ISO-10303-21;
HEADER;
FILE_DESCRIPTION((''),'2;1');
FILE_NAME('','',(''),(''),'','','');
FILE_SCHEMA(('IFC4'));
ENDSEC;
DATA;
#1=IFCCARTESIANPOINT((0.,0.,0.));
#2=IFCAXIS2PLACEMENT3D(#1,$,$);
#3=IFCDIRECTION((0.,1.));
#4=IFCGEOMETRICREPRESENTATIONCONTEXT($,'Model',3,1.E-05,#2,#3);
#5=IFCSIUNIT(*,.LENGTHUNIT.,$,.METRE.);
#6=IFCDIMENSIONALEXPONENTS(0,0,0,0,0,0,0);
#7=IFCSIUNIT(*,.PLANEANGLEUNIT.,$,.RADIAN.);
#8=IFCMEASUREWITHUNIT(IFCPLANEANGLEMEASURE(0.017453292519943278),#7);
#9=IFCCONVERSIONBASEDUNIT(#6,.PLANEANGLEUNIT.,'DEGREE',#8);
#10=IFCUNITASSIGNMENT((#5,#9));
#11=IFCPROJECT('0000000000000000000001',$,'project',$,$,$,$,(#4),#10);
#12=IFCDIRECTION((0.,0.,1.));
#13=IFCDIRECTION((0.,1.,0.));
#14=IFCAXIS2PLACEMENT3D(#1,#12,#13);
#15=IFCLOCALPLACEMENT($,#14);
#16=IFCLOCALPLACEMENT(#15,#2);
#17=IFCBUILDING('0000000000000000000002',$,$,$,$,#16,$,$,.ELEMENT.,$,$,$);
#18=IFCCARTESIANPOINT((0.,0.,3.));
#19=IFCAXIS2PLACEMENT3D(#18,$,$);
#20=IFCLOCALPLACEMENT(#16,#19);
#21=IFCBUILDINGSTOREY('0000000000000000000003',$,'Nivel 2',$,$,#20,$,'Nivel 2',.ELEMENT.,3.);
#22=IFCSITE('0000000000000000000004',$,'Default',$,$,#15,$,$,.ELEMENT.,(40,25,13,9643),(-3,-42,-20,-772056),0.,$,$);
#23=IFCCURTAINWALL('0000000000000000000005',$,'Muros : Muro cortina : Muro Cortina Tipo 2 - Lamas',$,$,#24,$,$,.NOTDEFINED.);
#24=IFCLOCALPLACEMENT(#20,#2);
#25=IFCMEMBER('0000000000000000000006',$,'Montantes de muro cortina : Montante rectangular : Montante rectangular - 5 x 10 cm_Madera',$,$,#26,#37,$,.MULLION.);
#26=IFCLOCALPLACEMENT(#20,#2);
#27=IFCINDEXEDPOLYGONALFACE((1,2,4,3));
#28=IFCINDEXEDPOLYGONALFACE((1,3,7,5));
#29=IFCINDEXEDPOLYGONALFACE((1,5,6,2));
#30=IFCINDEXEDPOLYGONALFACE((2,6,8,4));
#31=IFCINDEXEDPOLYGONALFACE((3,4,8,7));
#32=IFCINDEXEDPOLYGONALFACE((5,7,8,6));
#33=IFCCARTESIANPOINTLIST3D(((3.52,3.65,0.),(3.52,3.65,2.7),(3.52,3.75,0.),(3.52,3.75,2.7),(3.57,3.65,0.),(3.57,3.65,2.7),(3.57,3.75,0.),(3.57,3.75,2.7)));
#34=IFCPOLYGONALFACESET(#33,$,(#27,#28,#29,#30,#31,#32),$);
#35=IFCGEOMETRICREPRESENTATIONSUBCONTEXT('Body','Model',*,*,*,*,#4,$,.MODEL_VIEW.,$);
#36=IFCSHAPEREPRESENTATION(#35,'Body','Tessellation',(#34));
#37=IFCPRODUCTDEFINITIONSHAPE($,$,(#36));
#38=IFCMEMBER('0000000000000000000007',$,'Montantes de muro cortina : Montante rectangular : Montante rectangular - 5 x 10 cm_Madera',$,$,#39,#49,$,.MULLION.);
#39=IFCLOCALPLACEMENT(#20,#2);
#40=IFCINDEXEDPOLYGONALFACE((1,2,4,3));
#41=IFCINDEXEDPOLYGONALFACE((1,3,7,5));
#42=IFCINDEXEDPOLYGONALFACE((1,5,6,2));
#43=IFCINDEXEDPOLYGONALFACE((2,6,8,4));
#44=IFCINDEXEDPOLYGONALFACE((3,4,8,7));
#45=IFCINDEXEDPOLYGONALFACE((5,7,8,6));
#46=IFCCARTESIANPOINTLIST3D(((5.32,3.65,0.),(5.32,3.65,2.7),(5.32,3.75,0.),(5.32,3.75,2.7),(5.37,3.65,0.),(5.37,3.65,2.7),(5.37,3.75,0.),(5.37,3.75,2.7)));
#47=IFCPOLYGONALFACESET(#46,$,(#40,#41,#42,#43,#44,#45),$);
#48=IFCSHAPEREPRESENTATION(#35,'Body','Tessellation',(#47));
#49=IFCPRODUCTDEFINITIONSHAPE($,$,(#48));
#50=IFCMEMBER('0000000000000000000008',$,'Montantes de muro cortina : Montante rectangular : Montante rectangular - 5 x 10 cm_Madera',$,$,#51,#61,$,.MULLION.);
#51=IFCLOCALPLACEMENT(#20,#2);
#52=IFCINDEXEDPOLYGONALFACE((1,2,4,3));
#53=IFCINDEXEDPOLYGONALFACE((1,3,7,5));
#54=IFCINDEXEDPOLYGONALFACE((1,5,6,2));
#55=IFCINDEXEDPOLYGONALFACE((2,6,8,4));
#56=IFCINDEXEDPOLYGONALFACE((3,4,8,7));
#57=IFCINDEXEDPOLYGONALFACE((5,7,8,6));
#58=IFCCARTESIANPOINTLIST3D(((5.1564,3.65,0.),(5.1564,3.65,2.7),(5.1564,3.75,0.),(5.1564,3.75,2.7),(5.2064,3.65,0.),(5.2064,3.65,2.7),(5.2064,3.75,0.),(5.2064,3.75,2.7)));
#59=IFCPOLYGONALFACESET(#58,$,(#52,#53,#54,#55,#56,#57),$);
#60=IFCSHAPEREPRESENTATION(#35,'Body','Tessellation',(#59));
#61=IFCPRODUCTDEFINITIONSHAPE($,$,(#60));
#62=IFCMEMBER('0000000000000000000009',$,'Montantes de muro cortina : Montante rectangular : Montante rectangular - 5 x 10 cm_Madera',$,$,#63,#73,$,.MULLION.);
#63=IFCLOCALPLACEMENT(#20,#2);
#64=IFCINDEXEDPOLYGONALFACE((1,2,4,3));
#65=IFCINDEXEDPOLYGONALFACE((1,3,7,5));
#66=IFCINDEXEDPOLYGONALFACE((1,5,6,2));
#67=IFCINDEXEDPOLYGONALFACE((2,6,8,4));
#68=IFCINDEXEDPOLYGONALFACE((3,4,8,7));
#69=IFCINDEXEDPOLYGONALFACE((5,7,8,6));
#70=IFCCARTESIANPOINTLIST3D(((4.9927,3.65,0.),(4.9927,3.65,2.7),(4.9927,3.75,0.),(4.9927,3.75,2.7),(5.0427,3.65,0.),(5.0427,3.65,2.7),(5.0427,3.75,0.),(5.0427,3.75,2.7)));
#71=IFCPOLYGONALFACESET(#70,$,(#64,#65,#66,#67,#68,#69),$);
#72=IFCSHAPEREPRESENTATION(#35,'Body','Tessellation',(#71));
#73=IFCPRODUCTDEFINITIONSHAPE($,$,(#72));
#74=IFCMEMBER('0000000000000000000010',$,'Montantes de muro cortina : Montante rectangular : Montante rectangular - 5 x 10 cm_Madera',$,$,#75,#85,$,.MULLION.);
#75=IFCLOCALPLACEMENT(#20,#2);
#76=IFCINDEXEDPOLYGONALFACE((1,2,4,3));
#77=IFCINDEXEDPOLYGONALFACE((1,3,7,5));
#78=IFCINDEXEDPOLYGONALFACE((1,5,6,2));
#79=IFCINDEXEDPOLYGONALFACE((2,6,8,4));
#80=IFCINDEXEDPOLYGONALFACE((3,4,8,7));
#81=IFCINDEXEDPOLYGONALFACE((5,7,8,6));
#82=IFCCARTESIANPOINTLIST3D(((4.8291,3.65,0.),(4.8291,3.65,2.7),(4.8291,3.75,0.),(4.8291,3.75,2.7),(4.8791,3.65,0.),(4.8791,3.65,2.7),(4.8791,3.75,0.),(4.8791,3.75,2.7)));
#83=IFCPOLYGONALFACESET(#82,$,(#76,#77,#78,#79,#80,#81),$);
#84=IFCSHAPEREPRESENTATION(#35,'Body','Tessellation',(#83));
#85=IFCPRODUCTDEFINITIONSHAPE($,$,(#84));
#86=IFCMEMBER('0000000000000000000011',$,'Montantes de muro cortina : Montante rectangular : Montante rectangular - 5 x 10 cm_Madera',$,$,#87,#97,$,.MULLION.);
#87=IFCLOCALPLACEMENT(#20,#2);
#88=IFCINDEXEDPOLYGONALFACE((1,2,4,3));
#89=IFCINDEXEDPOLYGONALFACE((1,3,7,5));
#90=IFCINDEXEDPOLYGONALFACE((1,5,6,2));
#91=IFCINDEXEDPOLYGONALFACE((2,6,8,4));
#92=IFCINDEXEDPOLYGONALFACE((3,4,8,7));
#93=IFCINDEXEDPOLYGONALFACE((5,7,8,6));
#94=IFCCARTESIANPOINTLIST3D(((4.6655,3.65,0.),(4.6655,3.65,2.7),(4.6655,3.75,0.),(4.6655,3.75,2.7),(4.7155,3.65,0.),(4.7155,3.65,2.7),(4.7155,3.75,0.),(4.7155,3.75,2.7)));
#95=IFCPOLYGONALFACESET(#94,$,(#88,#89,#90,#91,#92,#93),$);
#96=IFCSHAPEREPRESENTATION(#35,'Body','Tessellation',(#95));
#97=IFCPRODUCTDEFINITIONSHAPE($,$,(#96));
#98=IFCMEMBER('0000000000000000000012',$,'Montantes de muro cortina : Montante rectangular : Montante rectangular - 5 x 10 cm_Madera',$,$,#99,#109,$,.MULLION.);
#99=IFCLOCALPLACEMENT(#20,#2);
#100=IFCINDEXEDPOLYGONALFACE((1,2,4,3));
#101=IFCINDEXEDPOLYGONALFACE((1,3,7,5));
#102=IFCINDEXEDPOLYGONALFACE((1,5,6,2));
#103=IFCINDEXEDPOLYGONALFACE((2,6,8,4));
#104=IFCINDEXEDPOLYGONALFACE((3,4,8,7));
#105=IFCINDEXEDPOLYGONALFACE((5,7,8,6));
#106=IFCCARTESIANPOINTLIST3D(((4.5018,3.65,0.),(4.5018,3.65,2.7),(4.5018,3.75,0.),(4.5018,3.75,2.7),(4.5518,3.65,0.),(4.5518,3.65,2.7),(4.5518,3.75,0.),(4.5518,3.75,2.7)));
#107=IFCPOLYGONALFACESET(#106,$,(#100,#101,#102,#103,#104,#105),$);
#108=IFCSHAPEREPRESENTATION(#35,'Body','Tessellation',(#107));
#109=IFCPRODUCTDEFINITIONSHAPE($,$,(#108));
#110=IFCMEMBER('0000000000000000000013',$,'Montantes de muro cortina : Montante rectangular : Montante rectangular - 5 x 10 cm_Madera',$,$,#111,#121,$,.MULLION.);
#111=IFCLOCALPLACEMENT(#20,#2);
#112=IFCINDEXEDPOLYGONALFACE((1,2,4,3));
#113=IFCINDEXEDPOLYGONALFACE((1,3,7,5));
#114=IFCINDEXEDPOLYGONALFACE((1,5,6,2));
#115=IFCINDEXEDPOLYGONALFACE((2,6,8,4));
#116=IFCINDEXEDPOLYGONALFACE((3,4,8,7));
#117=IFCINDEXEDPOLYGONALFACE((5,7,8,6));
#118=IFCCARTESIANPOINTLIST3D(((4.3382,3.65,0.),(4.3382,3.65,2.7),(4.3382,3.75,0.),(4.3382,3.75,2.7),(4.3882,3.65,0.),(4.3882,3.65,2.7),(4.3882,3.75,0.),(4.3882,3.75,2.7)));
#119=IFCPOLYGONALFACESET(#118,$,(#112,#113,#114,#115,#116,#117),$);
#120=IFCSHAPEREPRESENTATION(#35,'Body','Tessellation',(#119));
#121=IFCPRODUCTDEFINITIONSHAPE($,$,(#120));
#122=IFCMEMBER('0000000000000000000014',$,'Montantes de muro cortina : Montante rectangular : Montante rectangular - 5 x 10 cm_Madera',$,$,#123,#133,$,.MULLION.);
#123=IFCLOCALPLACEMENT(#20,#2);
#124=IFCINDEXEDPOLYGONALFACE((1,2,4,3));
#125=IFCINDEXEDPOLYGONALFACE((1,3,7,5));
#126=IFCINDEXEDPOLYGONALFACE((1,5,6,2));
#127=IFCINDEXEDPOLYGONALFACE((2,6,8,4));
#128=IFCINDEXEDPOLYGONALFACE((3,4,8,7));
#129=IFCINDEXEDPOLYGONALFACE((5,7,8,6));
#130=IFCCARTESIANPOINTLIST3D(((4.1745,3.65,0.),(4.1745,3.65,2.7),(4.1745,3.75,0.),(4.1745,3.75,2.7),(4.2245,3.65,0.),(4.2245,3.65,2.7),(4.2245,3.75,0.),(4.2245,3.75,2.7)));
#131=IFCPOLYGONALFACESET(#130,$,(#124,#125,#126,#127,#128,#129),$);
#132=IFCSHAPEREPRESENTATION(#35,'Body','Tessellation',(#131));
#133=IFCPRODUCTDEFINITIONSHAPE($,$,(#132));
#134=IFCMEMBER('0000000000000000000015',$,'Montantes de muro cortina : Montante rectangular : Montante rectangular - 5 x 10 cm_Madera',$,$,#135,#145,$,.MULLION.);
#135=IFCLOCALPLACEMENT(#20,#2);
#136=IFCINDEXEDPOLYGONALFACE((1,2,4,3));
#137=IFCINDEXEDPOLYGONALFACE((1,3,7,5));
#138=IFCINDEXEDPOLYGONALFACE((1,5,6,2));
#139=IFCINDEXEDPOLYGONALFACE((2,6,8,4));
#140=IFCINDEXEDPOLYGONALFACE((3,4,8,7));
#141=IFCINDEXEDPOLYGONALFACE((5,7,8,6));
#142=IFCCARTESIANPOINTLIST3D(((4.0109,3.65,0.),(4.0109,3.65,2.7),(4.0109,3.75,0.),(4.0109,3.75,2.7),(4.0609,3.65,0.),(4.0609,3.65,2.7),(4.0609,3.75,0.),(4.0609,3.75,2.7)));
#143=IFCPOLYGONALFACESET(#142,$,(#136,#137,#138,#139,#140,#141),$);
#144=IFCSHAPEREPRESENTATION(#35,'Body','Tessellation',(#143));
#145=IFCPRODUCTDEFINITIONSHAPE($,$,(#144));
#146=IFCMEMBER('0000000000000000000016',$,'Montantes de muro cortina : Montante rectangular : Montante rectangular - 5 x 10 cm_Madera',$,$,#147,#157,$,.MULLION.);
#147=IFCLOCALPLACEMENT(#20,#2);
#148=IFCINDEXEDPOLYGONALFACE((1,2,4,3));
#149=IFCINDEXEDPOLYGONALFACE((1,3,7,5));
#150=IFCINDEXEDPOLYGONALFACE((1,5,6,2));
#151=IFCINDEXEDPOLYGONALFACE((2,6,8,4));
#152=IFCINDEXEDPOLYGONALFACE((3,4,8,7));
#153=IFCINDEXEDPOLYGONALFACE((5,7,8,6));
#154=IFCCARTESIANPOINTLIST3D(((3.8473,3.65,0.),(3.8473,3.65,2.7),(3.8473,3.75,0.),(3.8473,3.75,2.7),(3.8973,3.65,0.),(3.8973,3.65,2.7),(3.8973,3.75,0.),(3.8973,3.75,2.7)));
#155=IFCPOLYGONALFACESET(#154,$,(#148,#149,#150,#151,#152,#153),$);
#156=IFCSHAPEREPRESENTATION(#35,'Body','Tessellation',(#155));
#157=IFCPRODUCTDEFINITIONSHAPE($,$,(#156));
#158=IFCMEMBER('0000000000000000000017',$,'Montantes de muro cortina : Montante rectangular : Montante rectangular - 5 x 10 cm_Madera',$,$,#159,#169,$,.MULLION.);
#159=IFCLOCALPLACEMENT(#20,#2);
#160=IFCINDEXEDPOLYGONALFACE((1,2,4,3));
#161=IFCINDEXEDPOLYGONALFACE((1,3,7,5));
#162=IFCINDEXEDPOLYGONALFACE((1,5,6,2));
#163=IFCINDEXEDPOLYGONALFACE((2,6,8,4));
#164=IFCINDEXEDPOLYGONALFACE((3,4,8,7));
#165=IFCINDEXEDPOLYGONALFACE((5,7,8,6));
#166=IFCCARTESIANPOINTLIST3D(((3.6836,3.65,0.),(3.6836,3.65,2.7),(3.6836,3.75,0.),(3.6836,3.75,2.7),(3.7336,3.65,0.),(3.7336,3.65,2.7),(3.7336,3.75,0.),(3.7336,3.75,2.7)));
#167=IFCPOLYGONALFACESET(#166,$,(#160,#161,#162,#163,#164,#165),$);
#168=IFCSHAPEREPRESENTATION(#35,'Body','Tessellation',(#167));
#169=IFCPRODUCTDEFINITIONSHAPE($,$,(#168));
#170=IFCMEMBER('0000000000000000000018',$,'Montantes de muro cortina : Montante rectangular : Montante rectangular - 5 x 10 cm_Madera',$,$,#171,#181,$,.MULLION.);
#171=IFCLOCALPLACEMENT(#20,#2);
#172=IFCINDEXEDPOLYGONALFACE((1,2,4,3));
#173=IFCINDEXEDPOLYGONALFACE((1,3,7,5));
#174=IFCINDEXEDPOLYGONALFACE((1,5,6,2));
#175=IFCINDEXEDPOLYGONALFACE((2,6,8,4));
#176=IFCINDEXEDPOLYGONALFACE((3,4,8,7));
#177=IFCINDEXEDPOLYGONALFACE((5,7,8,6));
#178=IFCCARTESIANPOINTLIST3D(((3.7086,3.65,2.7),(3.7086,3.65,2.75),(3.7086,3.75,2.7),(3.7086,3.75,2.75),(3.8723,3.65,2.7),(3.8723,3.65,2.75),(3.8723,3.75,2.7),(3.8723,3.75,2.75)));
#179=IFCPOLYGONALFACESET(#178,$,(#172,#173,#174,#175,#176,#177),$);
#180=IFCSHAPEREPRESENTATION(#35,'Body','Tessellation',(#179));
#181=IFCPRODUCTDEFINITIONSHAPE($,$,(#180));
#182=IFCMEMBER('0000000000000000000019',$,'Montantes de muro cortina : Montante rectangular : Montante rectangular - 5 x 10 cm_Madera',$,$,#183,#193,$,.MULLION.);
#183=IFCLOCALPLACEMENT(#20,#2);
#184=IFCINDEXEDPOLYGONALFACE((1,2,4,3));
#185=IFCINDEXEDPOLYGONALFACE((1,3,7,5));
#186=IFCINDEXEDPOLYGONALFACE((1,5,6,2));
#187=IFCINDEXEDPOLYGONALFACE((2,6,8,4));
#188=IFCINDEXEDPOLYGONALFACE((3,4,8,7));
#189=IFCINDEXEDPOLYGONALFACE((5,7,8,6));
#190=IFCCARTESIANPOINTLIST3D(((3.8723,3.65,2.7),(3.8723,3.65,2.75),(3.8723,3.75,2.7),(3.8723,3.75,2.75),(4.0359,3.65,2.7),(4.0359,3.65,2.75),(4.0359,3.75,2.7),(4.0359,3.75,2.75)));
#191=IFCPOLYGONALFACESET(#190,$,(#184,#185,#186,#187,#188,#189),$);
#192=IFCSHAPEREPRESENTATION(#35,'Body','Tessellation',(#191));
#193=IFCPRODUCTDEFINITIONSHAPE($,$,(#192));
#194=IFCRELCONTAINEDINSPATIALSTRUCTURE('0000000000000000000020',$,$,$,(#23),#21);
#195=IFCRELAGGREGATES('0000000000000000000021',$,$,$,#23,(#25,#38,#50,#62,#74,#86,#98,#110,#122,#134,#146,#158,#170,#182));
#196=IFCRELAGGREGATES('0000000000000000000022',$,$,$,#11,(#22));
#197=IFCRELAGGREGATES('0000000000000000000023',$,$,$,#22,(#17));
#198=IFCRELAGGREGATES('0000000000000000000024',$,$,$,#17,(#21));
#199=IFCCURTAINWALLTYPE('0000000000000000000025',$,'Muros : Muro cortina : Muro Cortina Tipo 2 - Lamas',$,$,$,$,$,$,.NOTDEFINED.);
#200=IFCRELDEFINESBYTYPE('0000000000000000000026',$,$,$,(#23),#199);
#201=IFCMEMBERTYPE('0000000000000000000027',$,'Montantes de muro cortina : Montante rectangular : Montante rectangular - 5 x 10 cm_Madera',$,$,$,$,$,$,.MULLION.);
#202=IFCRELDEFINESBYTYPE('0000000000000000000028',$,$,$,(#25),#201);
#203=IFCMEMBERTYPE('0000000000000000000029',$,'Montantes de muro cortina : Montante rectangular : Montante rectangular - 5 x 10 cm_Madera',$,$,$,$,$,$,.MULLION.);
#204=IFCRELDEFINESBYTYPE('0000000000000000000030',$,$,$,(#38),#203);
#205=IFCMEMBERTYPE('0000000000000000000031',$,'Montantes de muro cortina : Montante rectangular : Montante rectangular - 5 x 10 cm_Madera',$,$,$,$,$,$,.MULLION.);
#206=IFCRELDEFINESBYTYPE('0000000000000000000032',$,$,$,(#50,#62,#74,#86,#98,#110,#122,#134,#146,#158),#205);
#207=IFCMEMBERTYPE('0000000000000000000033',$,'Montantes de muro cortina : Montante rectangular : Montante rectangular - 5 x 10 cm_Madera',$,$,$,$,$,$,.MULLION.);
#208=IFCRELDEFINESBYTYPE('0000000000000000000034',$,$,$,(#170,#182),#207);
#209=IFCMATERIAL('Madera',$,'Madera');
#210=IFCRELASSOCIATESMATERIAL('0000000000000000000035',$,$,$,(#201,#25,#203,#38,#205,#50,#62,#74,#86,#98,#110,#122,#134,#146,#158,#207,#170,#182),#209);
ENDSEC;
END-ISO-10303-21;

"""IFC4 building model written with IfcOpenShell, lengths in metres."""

from ifc_helpers import new_model, entity, si_unit, converted_unit, direction, frame, origin, place, context, subcontext, project, spatial, indexed_curve, outline, extrude, source, transform, mapped, material, type_object, type_shapes, element, aggregate, save


model = new_model("IFC4")

# Units and contexts
model_context = context("Model", 3, precision=1e-05, world=origin(), true_north=direction((0.0, 1.0)))
body_context = subcontext(model_context, "Body", "Model", "MODEL_VIEW")
ifc_project = project(units=[si_unit("LENGTHUNIT", "METRE"), converted_unit("PLANEANGLEUNIT", "DEGREE", entity("IfcPlaneAngleMeasure", 0.017453292519943278), si_unit("PLANEANGLEUNIT", "RADIAN"), dimensions=[0, 0, 0, 0, 0, 0, 0])], contexts=[model_context])

# Site, building, storey
site_placement = place(None, frame((0.0, 0.0, 0.0), z_axis=(0.0, 0.0, 1.0), x_axis=(0.0, 1.0, 0.0)))
site = spatial("IfcSite", under=ifc_project, at=site_placement, Name="Default", CompositionType="ELEMENT", RefLatitude=(40, 25, 13, 9643), RefLongitude=(-3, -42, -20, -772056), RefElevation=0.0)
building_placement = place(site_placement, origin())
building = spatial("IfcBuilding", under=site, at=building_placement, CompositionType="ELEMENT")
storey_placement = place(building_placement, frame((0.0, 0.0, 3.0)))
storey = spatial("IfcBuildingStorey", under=building, at=storey_placement, Name="Nivel 2", LongName="Nivel 2", CompositionType="ELEMENT", Elevation=3.0)

# Curtain wall, members
curtain_wall_type = type_object("IfcCurtainWallType", Name="Muros : Muro cortina : Muro Cortina Tipo 2 - Lamas", PredefinedType="NOTDEFINED")
curtain_wall_placement = place(storey_placement, frame((0.0, 0.0, -3.0)))
curtain_wall = element("IfcCurtainWall", 1, at=curtain_wall_placement, inside=storey, type_object=curtain_wall_type, Name="Muros : Muro cortina : Muro Cortina Tipo 2 - Lamas", PredefinedType="NOTDEFINED")
ifc_material_1 = material(Name="Madera", Category="Madera")
member_type_1 = type_object("IfcMemberType", Name="Montantes de muro cortina : Montante rectangular : Montante rectangular - 5 x 10 cm_Madera", PredefinedType="MULLION", material=ifc_material_1)
shared_shape_1 = source(origin(), body_context, "Body", "SweptSolid", [
    extrude(outline(indexed_curve([(-0.025, -0.05), (0.025, -0.05), (0.025, 0.05), (-0.025, 0.05), (-0.025, -0.05)], self_intersect=False)), frame((-0.025, 0.0, -2.7), z_axis=(0.0, 0.0, 1.0), x_axis=(-1.0, 0.0, 0.0)), (0.0, 0.0, 1.0), 2.7),
])
type_shapes(member_type_1, [shared_shape_1])
member_1_placement = place(curtain_wall_placement, frame((3.52, 3.7, 3.0), z_axis=(0.0, 0.0, -1.0), x_axis=(-1.0, 0.0, 0.0)))
member_1 = element("IfcMember", 2, at=member_1_placement, type_object=member_type_1, material=ifc_material_1, Name="Montantes de muro cortina : Montante rectangular : Montante rectangular - 5 x 10 cm_Madera", PredefinedType="MULLION", context=body_context, shape_type="MappedRepresentation", body=[
    mapped(shared_shape_1, transform((0.0, 0.0, 0.0), scale=1.0)),
])
member_type_2 = type_object("IfcMemberType", Name="Montantes de muro cortina : Montante rectangular : Montante rectangular - 5 x 10 cm_Madera", PredefinedType="MULLION", material=ifc_material_1)
shared_shape_2 = source(origin(), body_context, "Body", "SweptSolid", [
    extrude(outline(indexed_curve([(-0.05, -0.025), (0.05, -0.025), (0.05, 0.025), (-0.05, 0.025), (-0.05, -0.025)], self_intersect=False)), frame((-0.025, 0.0, -2.7), z_axis=(0.0, 0.0, 1.0), x_axis=(0.0, -1.0, 0.0)), (0.0, 0.0, 1.0), 2.7),
])
type_shapes(member_type_2, [shared_shape_2])
member_2_placement = place(curtain_wall_placement, frame((5.37, 3.7, 5.7)))
member_2 = element("IfcMember", 3, at=member_2_placement, type_object=member_type_2, material=ifc_material_1, Name="Montantes de muro cortina : Montante rectangular : Montante rectangular - 5 x 10 cm_Madera", PredefinedType="MULLION", context=body_context, shape_type="MappedRepresentation", body=[
    mapped(shared_shape_2, transform((0.0, 0.0, 0.0), scale=1.0)),
])
member_type_3 = type_object("IfcMemberType", Name="Montantes de muro cortina : Montante rectangular : Montante rectangular - 5 x 10 cm_Madera", PredefinedType="MULLION", material=ifc_material_1)
shared_shape_3 = source(origin(), body_context, "Body", "SweptSolid", [
    extrude(outline(indexed_curve([(-0.025, -0.05), (0.025, -0.05), (0.025, 0.05), (-0.025, 0.05), (-0.025, -0.05)], self_intersect=False)), frame((0.0, 0.0, -2.7), z_axis=(0.0, 0.0, 1.0), x_axis=(-1.0, 0.0, 0.0)), (0.0, 0.0, 1.0), 2.7),
])
type_shapes(member_type_3, [shared_shape_3])
member_3_placement = place(curtain_wall_placement, frame((5.1814, 3.7, 3.0), z_axis=(0.0, 0.0, -1.0), x_axis=(-1.0, 0.0, 0.0)))
member_3 = element("IfcMember", 4, at=member_3_placement, type_object=member_type_3, material=ifc_material_1, Name="Montantes de muro cortina : Montante rectangular : Montante rectangular - 5 x 10 cm_Madera", PredefinedType="MULLION", context=body_context, shape_type="MappedRepresentation", body=[
    mapped(shared_shape_3, transform((0.0, 0.0, 0.0), scale=1.0)),
])
member_4_placement = place(curtain_wall_placement, frame((5.0177, 3.7, 3.0), z_axis=(0.0, 0.0, -1.0), x_axis=(-1.0, 0.0, 0.0)))
member_4 = element("IfcMember", 5, at=member_4_placement, type_object=member_type_3, material=ifc_material_1, Name="Montantes de muro cortina : Montante rectangular : Montante rectangular - 5 x 10 cm_Madera", PredefinedType="MULLION", context=body_context, shape_type="MappedRepresentation", body=[
    mapped(shared_shape_3, transform((0.0, 0.0, 0.0), scale=1.0)),
])
member_5_placement = place(curtain_wall_placement, frame((4.8541, 3.7, 3.0), z_axis=(0.0, 0.0, -1.0), x_axis=(-1.0, 0.0, 0.0)))
member_5 = element("IfcMember", 6, at=member_5_placement, type_object=member_type_3, material=ifc_material_1, Name="Montantes de muro cortina : Montante rectangular : Montante rectangular - 5 x 10 cm_Madera", PredefinedType="MULLION", context=body_context, shape_type="MappedRepresentation", body=[
    mapped(shared_shape_3, transform((0.0, 0.0, 0.0), scale=1.0)),
])
member_6_placement = place(curtain_wall_placement, frame((4.6905, 3.7, 3.0), z_axis=(0.0, 0.0, -1.0), x_axis=(-1.0, 0.0, 0.0)))
member_6 = element("IfcMember", 7, at=member_6_placement, type_object=member_type_3, material=ifc_material_1, Name="Montantes de muro cortina : Montante rectangular : Montante rectangular - 5 x 10 cm_Madera", PredefinedType="MULLION", context=body_context, shape_type="MappedRepresentation", body=[
    mapped(shared_shape_3, transform((0.0, 0.0, 0.0), scale=1.0)),
])
member_7_placement = place(curtain_wall_placement, frame((4.5268, 3.7, 3.0), z_axis=(0.0, 0.0, -1.0), x_axis=(-1.0, 0.0, 0.0)))
member_7 = element("IfcMember", 8, at=member_7_placement, type_object=member_type_3, material=ifc_material_1, Name="Montantes de muro cortina : Montante rectangular : Montante rectangular - 5 x 10 cm_Madera", PredefinedType="MULLION", context=body_context, shape_type="MappedRepresentation", body=[
    mapped(shared_shape_3, transform((0.0, 0.0, 0.0), scale=1.0)),
])
member_8_placement = place(curtain_wall_placement, frame((4.3632, 3.7, 3.0), z_axis=(0.0, 0.0, -1.0), x_axis=(-1.0, 0.0, 0.0)))
member_8 = element("IfcMember", 9, at=member_8_placement, type_object=member_type_3, material=ifc_material_1, Name="Montantes de muro cortina : Montante rectangular : Montante rectangular - 5 x 10 cm_Madera", PredefinedType="MULLION", context=body_context, shape_type="MappedRepresentation", body=[
    mapped(shared_shape_3, transform((0.0, 0.0, 0.0), scale=1.0)),
])
member_9_placement = place(curtain_wall_placement, frame((4.1995, 3.7, 3.0), z_axis=(0.0, 0.0, -1.0), x_axis=(-1.0, 0.0, 0.0)))
member_9 = element("IfcMember", 10, at=member_9_placement, type_object=member_type_3, material=ifc_material_1, Name="Montantes de muro cortina : Montante rectangular : Montante rectangular - 5 x 10 cm_Madera", PredefinedType="MULLION", context=body_context, shape_type="MappedRepresentation", body=[
    mapped(shared_shape_3, transform((0.0, 0.0, 0.0), scale=1.0)),
])
member_10_placement = place(curtain_wall_placement, frame((4.0359, 3.7, 3.0), z_axis=(0.0, 0.0, -1.0), x_axis=(-1.0, 0.0, 0.0)))
member_10 = element("IfcMember", 11, at=member_10_placement, type_object=member_type_3, material=ifc_material_1, Name="Montantes de muro cortina : Montante rectangular : Montante rectangular - 5 x 10 cm_Madera", PredefinedType="MULLION", context=body_context, shape_type="MappedRepresentation", body=[
    mapped(shared_shape_3, transform((0.0, 0.0, 0.0), scale=1.0)),
])
member_11_placement = place(curtain_wall_placement, frame((3.8723, 3.7, 3.0), z_axis=(0.0, 0.0, -1.0), x_axis=(-1.0, 0.0, 0.0)))
member_11 = element("IfcMember", 12, at=member_11_placement, type_object=member_type_3, material=ifc_material_1, Name="Montantes de muro cortina : Montante rectangular : Montante rectangular - 5 x 10 cm_Madera", PredefinedType="MULLION", context=body_context, shape_type="MappedRepresentation", body=[
    mapped(shared_shape_3, transform((0.0, 0.0, 0.0), scale=1.0)),
])
member_12_placement = place(curtain_wall_placement, frame((3.7086, 3.7, 3.0), z_axis=(0.0, 0.0, -1.0), x_axis=(-1.0, 0.0, 0.0)))
member_12 = element("IfcMember", 13, at=member_12_placement, type_object=member_type_3, material=ifc_material_1, Name="Montantes de muro cortina : Montante rectangular : Montante rectangular - 5 x 10 cm_Madera", PredefinedType="MULLION", context=body_context, shape_type="MappedRepresentation", body=[
    mapped(shared_shape_3, transform((0.0, 0.0, 0.0), scale=1.0)),
])
member_type_4 = type_object("IfcMemberType", Name="Montantes de muro cortina : Montante rectangular : Montante rectangular - 5 x 10 cm_Madera", PredefinedType="MULLION", material=ifc_material_1)
shared_shape_4 = source(origin(), body_context, "Body", "SweptSolid", [
    extrude(outline(indexed_curve([(-0.025, -0.05), (0.025, -0.05), (0.025, 0.05), (-0.025, 0.05), (-0.025, -0.05)], self_intersect=False)), frame((-0.025, 0.0, -0.1636), z_axis=(0.0, 0.0, 1.0), x_axis=(-1.0, 0.0, 0.0)), (0.0, 0.0, 1.0), 0.1636),
])
type_shapes(member_type_4, [shared_shape_4])
member_13_placement = place(curtain_wall_placement, frame((3.7086, 3.7, 5.75), z_axis=(-1.0, 0.0, 0.0), x_axis=(0.0, 0.0, 1.0)))
member_13 = element("IfcMember", 14, at=member_13_placement, type_object=member_type_4, material=ifc_material_1, Name="Montantes de muro cortina : Montante rectangular : Montante rectangular - 5 x 10 cm_Madera", PredefinedType="MULLION", context=body_context, shape_type="MappedRepresentation", body=[
    mapped(shared_shape_4, transform((0.0, 0.0, 0.0), scale=1.0)),
])
member_14_placement = place(curtain_wall_placement, frame((3.8723, 3.7, 5.75), z_axis=(-1.0, 0.0, 0.0), x_axis=(0.0, 0.0, 1.0)))
member_14 = element("IfcMember", 15, at=member_14_placement, type_object=member_type_4, material=ifc_material_1, Name="Montantes de muro cortina : Montante rectangular : Montante rectangular - 5 x 10 cm_Madera", PredefinedType="MULLION", context=body_context, shape_type="MappedRepresentation", body=[
    mapped(shared_shape_4, transform((0.0, 0.0, 0.0), scale=1.0)),
])
aggregate(curtain_wall, [member_1, member_2, member_3, member_4, member_5, member_6, member_7, member_8, member_9, member_10, member_11, member_12, member_13, member_14])

save(model, "model.ifc")
